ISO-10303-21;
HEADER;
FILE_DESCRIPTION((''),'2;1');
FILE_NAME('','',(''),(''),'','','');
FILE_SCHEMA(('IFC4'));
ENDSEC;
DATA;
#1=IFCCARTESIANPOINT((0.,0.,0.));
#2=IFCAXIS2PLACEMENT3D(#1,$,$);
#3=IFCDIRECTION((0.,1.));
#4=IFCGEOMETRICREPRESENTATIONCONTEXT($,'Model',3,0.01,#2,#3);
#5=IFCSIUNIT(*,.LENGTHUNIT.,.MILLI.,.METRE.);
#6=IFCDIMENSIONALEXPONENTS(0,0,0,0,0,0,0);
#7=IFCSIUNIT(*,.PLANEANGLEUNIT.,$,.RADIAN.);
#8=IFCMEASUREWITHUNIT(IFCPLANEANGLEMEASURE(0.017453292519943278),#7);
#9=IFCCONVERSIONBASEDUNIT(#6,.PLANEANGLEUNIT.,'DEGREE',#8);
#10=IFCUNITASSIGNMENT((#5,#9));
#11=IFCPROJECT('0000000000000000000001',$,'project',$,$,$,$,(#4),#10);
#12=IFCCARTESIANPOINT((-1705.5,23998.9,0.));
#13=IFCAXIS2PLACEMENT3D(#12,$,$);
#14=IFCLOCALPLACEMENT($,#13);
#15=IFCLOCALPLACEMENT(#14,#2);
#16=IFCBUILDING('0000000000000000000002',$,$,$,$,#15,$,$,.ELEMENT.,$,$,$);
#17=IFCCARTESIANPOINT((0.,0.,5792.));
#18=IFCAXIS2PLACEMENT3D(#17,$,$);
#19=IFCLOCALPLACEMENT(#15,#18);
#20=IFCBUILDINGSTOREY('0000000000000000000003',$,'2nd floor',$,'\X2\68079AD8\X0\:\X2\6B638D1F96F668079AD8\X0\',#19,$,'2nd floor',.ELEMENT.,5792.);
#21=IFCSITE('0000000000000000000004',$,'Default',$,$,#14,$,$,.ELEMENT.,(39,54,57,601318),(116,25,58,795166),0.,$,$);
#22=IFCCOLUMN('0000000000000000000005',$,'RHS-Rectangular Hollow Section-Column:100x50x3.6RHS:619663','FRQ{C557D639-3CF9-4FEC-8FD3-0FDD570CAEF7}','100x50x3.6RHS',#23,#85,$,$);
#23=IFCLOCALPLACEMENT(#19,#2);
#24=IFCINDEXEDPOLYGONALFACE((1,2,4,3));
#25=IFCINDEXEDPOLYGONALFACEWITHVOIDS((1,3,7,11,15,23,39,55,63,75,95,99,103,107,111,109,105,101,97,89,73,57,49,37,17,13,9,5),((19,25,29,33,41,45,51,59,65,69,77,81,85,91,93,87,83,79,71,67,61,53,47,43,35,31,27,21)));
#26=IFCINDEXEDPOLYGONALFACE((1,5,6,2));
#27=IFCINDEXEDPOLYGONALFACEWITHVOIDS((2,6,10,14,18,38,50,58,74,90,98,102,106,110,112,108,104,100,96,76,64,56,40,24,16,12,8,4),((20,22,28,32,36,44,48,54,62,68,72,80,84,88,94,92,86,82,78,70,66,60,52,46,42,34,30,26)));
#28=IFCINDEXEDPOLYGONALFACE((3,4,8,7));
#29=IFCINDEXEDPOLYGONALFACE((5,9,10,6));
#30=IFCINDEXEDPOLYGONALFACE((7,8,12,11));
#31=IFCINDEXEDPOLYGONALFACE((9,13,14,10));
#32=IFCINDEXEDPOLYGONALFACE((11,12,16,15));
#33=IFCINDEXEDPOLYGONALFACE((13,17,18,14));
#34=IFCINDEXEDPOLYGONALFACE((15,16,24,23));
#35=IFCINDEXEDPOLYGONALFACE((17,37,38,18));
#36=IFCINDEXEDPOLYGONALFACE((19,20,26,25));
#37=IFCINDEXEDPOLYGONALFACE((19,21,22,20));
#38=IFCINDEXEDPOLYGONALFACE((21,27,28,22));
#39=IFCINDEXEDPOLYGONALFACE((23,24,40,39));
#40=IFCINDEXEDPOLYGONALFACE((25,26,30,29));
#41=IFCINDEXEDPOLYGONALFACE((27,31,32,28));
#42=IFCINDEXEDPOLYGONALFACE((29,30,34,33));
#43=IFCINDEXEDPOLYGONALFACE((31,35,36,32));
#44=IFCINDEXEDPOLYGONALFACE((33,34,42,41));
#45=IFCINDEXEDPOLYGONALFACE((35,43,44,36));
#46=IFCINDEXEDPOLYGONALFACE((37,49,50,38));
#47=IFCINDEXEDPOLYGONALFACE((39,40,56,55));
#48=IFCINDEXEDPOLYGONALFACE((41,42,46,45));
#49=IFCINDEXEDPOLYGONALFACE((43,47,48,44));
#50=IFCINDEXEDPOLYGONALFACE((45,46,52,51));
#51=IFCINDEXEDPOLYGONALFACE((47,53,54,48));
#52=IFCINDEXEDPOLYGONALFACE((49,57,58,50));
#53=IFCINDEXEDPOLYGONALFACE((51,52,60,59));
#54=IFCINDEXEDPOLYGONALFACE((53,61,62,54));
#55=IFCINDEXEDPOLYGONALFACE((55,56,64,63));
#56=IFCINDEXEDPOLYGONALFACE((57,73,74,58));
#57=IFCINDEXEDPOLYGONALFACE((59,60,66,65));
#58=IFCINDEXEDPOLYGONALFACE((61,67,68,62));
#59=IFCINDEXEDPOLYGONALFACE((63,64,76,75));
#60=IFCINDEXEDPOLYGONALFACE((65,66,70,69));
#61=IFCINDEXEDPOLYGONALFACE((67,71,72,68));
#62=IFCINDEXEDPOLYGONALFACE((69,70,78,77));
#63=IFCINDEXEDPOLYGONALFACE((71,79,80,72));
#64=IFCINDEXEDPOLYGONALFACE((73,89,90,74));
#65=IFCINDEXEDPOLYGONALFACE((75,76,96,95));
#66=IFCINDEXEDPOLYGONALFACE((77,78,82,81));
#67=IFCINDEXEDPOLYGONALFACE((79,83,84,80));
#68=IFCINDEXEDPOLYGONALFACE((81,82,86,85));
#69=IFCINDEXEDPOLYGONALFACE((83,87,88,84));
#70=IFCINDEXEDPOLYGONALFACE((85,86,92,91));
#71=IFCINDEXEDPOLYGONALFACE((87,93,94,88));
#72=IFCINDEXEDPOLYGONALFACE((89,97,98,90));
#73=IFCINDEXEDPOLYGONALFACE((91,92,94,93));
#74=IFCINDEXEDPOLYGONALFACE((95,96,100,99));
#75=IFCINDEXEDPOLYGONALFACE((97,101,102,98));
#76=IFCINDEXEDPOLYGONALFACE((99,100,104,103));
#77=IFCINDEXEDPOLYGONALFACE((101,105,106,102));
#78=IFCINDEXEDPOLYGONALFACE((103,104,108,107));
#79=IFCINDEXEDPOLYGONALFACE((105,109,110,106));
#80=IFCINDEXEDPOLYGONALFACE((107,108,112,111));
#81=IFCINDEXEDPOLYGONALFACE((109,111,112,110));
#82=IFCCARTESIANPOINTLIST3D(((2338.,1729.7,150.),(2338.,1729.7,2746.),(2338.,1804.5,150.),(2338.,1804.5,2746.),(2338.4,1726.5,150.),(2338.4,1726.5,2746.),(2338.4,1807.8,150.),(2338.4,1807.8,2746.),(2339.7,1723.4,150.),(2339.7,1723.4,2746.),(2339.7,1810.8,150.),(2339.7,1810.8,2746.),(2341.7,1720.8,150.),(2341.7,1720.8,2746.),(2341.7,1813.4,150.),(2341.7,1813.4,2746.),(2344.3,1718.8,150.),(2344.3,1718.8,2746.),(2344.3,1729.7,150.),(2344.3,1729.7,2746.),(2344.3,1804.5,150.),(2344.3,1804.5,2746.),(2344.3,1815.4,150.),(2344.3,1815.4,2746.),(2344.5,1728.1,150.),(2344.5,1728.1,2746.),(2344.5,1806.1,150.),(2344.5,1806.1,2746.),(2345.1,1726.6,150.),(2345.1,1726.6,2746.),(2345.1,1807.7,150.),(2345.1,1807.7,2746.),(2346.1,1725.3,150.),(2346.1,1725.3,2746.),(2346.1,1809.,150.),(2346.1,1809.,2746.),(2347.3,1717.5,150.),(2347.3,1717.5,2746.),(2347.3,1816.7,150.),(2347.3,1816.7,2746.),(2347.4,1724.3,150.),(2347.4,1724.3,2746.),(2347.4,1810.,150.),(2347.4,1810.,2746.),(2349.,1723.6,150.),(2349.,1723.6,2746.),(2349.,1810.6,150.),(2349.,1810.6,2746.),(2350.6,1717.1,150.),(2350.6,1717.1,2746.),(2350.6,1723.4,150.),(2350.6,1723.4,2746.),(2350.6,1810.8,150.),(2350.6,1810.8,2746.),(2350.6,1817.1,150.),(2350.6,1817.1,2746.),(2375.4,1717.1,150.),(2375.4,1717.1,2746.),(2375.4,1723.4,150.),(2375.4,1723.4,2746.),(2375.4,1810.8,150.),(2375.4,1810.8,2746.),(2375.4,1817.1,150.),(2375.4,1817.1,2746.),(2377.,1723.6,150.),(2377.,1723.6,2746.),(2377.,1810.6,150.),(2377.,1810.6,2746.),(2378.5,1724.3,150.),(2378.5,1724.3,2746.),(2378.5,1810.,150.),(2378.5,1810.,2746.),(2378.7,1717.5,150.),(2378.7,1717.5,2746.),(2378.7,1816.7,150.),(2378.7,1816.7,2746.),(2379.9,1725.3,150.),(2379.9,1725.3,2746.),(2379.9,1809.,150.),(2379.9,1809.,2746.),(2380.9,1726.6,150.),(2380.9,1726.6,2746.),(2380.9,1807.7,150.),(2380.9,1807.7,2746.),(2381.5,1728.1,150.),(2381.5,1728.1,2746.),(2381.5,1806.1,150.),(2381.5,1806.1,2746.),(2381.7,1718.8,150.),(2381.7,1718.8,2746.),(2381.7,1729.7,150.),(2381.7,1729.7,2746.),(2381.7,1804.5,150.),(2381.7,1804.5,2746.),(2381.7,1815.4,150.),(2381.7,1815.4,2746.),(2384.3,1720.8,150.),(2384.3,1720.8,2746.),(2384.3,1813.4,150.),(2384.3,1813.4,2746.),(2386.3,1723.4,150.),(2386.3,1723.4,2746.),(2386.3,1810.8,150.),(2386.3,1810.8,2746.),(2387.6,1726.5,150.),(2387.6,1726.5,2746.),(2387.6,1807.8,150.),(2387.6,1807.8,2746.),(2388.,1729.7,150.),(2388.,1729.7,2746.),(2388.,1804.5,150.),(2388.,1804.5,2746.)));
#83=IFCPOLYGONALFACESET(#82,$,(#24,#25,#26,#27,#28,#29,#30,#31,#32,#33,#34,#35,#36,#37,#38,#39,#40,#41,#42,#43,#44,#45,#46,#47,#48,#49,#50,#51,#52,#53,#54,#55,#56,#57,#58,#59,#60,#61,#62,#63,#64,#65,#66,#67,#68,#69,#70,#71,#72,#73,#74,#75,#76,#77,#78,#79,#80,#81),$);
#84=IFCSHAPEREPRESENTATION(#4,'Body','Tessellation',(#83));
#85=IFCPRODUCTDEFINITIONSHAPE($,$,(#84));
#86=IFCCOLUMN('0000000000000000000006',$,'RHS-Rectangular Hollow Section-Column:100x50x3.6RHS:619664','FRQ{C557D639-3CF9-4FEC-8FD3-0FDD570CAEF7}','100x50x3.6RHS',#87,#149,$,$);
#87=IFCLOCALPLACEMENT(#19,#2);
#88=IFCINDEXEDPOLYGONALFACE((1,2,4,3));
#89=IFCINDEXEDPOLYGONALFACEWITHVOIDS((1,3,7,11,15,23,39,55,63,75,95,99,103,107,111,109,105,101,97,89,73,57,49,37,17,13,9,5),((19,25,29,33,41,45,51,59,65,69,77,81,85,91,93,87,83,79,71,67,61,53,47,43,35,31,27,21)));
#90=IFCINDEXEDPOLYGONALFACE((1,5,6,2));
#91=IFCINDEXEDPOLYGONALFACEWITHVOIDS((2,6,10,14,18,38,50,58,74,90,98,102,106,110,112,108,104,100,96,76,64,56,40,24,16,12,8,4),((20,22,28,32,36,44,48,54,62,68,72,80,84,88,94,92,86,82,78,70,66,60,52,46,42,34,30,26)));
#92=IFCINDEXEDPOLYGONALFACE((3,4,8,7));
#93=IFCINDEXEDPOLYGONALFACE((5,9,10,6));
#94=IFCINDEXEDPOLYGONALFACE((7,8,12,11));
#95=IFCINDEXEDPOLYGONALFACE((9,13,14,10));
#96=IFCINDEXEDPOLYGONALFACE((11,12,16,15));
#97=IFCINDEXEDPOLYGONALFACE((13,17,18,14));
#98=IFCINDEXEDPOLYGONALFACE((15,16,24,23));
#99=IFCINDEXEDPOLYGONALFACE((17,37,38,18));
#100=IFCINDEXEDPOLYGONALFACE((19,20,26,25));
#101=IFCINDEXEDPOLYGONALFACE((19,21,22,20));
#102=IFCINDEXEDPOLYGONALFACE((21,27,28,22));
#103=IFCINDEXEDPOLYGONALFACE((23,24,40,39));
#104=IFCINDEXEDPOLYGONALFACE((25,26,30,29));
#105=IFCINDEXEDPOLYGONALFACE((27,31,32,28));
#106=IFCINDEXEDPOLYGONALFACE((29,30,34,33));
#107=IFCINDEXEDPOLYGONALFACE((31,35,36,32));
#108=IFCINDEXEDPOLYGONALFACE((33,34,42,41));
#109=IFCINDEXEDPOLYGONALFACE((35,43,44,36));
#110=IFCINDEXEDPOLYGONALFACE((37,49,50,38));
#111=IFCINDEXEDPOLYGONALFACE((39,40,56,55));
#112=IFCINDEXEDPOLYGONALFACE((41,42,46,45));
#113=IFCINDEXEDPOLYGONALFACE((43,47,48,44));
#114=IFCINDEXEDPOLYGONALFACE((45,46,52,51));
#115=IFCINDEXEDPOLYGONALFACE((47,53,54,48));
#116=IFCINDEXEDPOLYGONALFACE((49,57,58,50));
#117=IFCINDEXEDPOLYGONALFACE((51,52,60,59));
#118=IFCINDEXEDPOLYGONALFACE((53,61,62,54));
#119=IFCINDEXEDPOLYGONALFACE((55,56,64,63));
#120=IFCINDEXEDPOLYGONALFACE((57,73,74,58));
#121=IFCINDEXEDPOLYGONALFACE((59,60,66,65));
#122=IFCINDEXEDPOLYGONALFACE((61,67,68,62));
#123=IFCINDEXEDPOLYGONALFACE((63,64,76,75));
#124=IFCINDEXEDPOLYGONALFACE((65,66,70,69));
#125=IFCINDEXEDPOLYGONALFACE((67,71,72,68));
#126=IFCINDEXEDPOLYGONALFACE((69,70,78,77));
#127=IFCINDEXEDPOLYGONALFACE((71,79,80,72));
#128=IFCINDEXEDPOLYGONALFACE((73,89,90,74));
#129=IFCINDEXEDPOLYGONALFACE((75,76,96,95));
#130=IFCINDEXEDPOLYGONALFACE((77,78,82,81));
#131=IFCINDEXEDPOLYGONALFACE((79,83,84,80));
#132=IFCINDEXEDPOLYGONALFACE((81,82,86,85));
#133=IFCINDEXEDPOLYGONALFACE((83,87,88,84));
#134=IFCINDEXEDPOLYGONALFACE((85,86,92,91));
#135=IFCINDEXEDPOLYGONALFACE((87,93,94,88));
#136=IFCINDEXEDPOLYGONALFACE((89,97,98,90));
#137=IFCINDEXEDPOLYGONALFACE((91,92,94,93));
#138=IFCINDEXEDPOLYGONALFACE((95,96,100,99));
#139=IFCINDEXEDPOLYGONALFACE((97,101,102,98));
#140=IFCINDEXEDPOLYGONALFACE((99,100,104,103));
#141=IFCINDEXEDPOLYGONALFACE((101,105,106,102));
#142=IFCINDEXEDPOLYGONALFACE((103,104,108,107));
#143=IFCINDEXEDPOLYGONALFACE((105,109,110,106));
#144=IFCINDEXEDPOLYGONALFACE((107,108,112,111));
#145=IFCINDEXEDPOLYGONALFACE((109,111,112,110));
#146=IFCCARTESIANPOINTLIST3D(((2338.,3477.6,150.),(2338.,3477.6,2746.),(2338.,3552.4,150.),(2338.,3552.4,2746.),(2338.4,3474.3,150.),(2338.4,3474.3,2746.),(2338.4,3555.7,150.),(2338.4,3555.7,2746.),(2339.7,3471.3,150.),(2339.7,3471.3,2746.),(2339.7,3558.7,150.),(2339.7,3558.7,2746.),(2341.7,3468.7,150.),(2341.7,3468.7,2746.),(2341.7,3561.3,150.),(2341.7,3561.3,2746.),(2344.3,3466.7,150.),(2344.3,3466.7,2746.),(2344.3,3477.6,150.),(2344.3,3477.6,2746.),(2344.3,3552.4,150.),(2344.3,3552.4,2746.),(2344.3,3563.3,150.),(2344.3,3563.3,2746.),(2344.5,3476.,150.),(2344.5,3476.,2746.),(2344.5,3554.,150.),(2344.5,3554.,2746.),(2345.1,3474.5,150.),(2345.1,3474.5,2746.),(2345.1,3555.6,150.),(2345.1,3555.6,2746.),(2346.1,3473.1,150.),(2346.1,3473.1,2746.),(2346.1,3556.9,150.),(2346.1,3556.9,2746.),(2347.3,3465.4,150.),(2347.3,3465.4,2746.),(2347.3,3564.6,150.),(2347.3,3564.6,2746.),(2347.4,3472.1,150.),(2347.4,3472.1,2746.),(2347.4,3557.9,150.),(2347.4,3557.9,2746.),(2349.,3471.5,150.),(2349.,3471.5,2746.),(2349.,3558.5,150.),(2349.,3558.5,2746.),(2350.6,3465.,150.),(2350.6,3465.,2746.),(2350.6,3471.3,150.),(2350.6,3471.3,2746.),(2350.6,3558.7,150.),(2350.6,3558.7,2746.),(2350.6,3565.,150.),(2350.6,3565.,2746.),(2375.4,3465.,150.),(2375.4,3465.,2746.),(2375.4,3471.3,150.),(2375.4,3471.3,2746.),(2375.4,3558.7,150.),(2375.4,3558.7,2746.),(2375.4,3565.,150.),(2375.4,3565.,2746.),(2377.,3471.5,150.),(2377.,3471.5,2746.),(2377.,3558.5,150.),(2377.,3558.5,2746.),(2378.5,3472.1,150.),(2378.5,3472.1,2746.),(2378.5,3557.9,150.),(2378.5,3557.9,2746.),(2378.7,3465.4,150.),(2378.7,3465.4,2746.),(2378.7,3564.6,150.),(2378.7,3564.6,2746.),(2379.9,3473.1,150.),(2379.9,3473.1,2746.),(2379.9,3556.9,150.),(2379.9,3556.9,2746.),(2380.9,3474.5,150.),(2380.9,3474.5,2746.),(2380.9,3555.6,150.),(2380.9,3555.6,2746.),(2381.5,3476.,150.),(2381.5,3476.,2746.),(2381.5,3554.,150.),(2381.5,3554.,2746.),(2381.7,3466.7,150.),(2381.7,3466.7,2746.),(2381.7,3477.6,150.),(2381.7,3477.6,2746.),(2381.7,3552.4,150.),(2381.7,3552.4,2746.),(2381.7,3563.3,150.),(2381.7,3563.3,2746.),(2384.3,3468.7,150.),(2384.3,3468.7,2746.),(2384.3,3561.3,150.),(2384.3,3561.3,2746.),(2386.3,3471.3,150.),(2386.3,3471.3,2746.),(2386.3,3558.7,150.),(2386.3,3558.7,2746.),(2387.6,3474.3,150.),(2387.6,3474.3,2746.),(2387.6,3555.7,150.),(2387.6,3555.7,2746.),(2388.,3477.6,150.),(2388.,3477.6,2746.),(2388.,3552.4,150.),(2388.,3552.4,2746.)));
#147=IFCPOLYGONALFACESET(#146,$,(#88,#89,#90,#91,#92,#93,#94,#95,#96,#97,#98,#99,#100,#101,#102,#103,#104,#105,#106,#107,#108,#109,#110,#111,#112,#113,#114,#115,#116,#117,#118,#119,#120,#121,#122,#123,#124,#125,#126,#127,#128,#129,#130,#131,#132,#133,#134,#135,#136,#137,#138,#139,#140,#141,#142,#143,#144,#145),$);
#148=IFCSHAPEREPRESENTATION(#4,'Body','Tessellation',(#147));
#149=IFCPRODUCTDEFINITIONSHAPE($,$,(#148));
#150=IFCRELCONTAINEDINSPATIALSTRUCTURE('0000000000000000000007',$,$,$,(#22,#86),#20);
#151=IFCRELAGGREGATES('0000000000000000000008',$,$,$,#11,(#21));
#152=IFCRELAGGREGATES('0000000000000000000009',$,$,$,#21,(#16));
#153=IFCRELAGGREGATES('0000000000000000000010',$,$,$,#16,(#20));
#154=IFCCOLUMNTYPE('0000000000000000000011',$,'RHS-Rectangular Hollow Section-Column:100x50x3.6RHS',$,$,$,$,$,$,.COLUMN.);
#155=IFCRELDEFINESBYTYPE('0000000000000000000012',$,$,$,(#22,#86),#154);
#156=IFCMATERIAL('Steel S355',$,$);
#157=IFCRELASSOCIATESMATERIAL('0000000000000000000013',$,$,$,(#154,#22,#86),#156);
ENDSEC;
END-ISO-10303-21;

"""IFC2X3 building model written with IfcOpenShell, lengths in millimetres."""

from ifc_helpers import new_model, entity, si_unit, converted_unit, direction, frame, origin, origin_2d, place, context, project, spatial, hollow_rectangle, extrude, clip, halfspace, material, type_object, element, save


model = new_model("IFC2X3")

# Units and contexts
model_context = context("Model", 3, precision=0.01, world=origin(), true_north=direction((0.0, 1.0)))
ifc_project = project(units=[si_unit("LENGTHUNIT", "METRE", prefix="MILLI"), converted_unit("PLANEANGLEUNIT", "DEGREE", entity("IfcPlaneAngleMeasure", 0.017453292519943278), si_unit("PLANEANGLEUNIT", "RADIAN"), dimensions=[0, 0, 0, 0, 0, 0, 0])], contexts=[model_context])

# Site, building, storey
site_placement = place(None, frame((-1705.5, 23998.9, 0.0)))
site = spatial("IfcSite", under=ifc_project, at=site_placement, Name="Default", CompositionType="ELEMENT", RefLatitude=(39, 54, 57, 601318), RefLongitude=(116, 25, 58, 795166), RefElevation=0.0)
building_placement = place(site_placement, origin())
building = spatial("IfcBuilding", under=site, at=building_placement, CompositionType="ELEMENT")
storey_placement = place(building_placement, frame((0.0, 0.0, 5792.0)))
storey = spatial("IfcBuildingStorey", under=building, at=storey_placement, Name="2nd floor", ObjectType="标高:正负零标高", LongName="2nd floor", CompositionType="ELEMENT", Elevation=5792.0)

# Shared definitions
ifc_material_1 = material(Name="Steel S355")

# Columns
column_type_1 = type_object("IfcColumnType", Name="RHS-Rectangular Hollow Section-Column:100x50x3.6RHS", PredefinedType="COLUMN", material=ifc_material_1)
column_1_placement = place(storey_placement, frame((2363.0, 1767.1, 2746.0), z_axis=(0.0, 0.0, 1.0), x_axis=(-1.0, 0.0, 0.0)))
element("IfcColumn", 1, at=column_1_placement, inside=storey, type_object=column_type_1, material=ifc_material_1, Name="RHS-Rectangular Hollow Section-Column:100x50x3.6RHS:619663", Description="FRQ{C557D639-3CF9-4FEC-8FD3-0FDD570CAEF7}", ObjectType="100x50x3.6RHS", context=model_context, shape_type="Clipping", body=[
    clip(extrude(hollow_rectangle(XDim=50.0, YDim=100.0, WallThickness=6.3, InnerFilletRadius=6.3, OuterFilletRadius=12.6, at=origin_2d()), origin(), (0.0, 0.0, -1.0), 2651.9), halfspace(frame((2363.0, 1767.1, -2596.0), z_axis=(0.0, 0.0, 1.0), x_axis=(-1.0, 0.0, 0.0)), True)),
])
column_2_placement = place(storey_placement, frame((2363.0, 3515.0, 2746.0), z_axis=(0.0, 0.0, 1.0), x_axis=(-1.0, 0.0, 0.0)))
element("IfcColumn", 2, at=column_2_placement, inside=storey, type_object=column_type_1, material=ifc_material_1, Name="RHS-Rectangular Hollow Section-Column:100x50x3.6RHS:619664", Description="FRQ{C557D639-3CF9-4FEC-8FD3-0FDD570CAEF7}", ObjectType="100x50x3.6RHS", context=model_context, shape_type="Clipping", body=[
    clip(extrude(hollow_rectangle(XDim=50.0, YDim=100.0, WallThickness=6.3, InnerFilletRadius=6.3, OuterFilletRadius=12.6, at=origin_2d()), origin(), (0.0, 0.0, -1.0), 2651.9), halfspace(frame((2363.0, 3515.0, -2596.0), z_axis=(0.0, 0.0, 1.0), x_axis=(-1.0, 0.0, 0.0)), True)),
])

save(model, "model.ifc")
